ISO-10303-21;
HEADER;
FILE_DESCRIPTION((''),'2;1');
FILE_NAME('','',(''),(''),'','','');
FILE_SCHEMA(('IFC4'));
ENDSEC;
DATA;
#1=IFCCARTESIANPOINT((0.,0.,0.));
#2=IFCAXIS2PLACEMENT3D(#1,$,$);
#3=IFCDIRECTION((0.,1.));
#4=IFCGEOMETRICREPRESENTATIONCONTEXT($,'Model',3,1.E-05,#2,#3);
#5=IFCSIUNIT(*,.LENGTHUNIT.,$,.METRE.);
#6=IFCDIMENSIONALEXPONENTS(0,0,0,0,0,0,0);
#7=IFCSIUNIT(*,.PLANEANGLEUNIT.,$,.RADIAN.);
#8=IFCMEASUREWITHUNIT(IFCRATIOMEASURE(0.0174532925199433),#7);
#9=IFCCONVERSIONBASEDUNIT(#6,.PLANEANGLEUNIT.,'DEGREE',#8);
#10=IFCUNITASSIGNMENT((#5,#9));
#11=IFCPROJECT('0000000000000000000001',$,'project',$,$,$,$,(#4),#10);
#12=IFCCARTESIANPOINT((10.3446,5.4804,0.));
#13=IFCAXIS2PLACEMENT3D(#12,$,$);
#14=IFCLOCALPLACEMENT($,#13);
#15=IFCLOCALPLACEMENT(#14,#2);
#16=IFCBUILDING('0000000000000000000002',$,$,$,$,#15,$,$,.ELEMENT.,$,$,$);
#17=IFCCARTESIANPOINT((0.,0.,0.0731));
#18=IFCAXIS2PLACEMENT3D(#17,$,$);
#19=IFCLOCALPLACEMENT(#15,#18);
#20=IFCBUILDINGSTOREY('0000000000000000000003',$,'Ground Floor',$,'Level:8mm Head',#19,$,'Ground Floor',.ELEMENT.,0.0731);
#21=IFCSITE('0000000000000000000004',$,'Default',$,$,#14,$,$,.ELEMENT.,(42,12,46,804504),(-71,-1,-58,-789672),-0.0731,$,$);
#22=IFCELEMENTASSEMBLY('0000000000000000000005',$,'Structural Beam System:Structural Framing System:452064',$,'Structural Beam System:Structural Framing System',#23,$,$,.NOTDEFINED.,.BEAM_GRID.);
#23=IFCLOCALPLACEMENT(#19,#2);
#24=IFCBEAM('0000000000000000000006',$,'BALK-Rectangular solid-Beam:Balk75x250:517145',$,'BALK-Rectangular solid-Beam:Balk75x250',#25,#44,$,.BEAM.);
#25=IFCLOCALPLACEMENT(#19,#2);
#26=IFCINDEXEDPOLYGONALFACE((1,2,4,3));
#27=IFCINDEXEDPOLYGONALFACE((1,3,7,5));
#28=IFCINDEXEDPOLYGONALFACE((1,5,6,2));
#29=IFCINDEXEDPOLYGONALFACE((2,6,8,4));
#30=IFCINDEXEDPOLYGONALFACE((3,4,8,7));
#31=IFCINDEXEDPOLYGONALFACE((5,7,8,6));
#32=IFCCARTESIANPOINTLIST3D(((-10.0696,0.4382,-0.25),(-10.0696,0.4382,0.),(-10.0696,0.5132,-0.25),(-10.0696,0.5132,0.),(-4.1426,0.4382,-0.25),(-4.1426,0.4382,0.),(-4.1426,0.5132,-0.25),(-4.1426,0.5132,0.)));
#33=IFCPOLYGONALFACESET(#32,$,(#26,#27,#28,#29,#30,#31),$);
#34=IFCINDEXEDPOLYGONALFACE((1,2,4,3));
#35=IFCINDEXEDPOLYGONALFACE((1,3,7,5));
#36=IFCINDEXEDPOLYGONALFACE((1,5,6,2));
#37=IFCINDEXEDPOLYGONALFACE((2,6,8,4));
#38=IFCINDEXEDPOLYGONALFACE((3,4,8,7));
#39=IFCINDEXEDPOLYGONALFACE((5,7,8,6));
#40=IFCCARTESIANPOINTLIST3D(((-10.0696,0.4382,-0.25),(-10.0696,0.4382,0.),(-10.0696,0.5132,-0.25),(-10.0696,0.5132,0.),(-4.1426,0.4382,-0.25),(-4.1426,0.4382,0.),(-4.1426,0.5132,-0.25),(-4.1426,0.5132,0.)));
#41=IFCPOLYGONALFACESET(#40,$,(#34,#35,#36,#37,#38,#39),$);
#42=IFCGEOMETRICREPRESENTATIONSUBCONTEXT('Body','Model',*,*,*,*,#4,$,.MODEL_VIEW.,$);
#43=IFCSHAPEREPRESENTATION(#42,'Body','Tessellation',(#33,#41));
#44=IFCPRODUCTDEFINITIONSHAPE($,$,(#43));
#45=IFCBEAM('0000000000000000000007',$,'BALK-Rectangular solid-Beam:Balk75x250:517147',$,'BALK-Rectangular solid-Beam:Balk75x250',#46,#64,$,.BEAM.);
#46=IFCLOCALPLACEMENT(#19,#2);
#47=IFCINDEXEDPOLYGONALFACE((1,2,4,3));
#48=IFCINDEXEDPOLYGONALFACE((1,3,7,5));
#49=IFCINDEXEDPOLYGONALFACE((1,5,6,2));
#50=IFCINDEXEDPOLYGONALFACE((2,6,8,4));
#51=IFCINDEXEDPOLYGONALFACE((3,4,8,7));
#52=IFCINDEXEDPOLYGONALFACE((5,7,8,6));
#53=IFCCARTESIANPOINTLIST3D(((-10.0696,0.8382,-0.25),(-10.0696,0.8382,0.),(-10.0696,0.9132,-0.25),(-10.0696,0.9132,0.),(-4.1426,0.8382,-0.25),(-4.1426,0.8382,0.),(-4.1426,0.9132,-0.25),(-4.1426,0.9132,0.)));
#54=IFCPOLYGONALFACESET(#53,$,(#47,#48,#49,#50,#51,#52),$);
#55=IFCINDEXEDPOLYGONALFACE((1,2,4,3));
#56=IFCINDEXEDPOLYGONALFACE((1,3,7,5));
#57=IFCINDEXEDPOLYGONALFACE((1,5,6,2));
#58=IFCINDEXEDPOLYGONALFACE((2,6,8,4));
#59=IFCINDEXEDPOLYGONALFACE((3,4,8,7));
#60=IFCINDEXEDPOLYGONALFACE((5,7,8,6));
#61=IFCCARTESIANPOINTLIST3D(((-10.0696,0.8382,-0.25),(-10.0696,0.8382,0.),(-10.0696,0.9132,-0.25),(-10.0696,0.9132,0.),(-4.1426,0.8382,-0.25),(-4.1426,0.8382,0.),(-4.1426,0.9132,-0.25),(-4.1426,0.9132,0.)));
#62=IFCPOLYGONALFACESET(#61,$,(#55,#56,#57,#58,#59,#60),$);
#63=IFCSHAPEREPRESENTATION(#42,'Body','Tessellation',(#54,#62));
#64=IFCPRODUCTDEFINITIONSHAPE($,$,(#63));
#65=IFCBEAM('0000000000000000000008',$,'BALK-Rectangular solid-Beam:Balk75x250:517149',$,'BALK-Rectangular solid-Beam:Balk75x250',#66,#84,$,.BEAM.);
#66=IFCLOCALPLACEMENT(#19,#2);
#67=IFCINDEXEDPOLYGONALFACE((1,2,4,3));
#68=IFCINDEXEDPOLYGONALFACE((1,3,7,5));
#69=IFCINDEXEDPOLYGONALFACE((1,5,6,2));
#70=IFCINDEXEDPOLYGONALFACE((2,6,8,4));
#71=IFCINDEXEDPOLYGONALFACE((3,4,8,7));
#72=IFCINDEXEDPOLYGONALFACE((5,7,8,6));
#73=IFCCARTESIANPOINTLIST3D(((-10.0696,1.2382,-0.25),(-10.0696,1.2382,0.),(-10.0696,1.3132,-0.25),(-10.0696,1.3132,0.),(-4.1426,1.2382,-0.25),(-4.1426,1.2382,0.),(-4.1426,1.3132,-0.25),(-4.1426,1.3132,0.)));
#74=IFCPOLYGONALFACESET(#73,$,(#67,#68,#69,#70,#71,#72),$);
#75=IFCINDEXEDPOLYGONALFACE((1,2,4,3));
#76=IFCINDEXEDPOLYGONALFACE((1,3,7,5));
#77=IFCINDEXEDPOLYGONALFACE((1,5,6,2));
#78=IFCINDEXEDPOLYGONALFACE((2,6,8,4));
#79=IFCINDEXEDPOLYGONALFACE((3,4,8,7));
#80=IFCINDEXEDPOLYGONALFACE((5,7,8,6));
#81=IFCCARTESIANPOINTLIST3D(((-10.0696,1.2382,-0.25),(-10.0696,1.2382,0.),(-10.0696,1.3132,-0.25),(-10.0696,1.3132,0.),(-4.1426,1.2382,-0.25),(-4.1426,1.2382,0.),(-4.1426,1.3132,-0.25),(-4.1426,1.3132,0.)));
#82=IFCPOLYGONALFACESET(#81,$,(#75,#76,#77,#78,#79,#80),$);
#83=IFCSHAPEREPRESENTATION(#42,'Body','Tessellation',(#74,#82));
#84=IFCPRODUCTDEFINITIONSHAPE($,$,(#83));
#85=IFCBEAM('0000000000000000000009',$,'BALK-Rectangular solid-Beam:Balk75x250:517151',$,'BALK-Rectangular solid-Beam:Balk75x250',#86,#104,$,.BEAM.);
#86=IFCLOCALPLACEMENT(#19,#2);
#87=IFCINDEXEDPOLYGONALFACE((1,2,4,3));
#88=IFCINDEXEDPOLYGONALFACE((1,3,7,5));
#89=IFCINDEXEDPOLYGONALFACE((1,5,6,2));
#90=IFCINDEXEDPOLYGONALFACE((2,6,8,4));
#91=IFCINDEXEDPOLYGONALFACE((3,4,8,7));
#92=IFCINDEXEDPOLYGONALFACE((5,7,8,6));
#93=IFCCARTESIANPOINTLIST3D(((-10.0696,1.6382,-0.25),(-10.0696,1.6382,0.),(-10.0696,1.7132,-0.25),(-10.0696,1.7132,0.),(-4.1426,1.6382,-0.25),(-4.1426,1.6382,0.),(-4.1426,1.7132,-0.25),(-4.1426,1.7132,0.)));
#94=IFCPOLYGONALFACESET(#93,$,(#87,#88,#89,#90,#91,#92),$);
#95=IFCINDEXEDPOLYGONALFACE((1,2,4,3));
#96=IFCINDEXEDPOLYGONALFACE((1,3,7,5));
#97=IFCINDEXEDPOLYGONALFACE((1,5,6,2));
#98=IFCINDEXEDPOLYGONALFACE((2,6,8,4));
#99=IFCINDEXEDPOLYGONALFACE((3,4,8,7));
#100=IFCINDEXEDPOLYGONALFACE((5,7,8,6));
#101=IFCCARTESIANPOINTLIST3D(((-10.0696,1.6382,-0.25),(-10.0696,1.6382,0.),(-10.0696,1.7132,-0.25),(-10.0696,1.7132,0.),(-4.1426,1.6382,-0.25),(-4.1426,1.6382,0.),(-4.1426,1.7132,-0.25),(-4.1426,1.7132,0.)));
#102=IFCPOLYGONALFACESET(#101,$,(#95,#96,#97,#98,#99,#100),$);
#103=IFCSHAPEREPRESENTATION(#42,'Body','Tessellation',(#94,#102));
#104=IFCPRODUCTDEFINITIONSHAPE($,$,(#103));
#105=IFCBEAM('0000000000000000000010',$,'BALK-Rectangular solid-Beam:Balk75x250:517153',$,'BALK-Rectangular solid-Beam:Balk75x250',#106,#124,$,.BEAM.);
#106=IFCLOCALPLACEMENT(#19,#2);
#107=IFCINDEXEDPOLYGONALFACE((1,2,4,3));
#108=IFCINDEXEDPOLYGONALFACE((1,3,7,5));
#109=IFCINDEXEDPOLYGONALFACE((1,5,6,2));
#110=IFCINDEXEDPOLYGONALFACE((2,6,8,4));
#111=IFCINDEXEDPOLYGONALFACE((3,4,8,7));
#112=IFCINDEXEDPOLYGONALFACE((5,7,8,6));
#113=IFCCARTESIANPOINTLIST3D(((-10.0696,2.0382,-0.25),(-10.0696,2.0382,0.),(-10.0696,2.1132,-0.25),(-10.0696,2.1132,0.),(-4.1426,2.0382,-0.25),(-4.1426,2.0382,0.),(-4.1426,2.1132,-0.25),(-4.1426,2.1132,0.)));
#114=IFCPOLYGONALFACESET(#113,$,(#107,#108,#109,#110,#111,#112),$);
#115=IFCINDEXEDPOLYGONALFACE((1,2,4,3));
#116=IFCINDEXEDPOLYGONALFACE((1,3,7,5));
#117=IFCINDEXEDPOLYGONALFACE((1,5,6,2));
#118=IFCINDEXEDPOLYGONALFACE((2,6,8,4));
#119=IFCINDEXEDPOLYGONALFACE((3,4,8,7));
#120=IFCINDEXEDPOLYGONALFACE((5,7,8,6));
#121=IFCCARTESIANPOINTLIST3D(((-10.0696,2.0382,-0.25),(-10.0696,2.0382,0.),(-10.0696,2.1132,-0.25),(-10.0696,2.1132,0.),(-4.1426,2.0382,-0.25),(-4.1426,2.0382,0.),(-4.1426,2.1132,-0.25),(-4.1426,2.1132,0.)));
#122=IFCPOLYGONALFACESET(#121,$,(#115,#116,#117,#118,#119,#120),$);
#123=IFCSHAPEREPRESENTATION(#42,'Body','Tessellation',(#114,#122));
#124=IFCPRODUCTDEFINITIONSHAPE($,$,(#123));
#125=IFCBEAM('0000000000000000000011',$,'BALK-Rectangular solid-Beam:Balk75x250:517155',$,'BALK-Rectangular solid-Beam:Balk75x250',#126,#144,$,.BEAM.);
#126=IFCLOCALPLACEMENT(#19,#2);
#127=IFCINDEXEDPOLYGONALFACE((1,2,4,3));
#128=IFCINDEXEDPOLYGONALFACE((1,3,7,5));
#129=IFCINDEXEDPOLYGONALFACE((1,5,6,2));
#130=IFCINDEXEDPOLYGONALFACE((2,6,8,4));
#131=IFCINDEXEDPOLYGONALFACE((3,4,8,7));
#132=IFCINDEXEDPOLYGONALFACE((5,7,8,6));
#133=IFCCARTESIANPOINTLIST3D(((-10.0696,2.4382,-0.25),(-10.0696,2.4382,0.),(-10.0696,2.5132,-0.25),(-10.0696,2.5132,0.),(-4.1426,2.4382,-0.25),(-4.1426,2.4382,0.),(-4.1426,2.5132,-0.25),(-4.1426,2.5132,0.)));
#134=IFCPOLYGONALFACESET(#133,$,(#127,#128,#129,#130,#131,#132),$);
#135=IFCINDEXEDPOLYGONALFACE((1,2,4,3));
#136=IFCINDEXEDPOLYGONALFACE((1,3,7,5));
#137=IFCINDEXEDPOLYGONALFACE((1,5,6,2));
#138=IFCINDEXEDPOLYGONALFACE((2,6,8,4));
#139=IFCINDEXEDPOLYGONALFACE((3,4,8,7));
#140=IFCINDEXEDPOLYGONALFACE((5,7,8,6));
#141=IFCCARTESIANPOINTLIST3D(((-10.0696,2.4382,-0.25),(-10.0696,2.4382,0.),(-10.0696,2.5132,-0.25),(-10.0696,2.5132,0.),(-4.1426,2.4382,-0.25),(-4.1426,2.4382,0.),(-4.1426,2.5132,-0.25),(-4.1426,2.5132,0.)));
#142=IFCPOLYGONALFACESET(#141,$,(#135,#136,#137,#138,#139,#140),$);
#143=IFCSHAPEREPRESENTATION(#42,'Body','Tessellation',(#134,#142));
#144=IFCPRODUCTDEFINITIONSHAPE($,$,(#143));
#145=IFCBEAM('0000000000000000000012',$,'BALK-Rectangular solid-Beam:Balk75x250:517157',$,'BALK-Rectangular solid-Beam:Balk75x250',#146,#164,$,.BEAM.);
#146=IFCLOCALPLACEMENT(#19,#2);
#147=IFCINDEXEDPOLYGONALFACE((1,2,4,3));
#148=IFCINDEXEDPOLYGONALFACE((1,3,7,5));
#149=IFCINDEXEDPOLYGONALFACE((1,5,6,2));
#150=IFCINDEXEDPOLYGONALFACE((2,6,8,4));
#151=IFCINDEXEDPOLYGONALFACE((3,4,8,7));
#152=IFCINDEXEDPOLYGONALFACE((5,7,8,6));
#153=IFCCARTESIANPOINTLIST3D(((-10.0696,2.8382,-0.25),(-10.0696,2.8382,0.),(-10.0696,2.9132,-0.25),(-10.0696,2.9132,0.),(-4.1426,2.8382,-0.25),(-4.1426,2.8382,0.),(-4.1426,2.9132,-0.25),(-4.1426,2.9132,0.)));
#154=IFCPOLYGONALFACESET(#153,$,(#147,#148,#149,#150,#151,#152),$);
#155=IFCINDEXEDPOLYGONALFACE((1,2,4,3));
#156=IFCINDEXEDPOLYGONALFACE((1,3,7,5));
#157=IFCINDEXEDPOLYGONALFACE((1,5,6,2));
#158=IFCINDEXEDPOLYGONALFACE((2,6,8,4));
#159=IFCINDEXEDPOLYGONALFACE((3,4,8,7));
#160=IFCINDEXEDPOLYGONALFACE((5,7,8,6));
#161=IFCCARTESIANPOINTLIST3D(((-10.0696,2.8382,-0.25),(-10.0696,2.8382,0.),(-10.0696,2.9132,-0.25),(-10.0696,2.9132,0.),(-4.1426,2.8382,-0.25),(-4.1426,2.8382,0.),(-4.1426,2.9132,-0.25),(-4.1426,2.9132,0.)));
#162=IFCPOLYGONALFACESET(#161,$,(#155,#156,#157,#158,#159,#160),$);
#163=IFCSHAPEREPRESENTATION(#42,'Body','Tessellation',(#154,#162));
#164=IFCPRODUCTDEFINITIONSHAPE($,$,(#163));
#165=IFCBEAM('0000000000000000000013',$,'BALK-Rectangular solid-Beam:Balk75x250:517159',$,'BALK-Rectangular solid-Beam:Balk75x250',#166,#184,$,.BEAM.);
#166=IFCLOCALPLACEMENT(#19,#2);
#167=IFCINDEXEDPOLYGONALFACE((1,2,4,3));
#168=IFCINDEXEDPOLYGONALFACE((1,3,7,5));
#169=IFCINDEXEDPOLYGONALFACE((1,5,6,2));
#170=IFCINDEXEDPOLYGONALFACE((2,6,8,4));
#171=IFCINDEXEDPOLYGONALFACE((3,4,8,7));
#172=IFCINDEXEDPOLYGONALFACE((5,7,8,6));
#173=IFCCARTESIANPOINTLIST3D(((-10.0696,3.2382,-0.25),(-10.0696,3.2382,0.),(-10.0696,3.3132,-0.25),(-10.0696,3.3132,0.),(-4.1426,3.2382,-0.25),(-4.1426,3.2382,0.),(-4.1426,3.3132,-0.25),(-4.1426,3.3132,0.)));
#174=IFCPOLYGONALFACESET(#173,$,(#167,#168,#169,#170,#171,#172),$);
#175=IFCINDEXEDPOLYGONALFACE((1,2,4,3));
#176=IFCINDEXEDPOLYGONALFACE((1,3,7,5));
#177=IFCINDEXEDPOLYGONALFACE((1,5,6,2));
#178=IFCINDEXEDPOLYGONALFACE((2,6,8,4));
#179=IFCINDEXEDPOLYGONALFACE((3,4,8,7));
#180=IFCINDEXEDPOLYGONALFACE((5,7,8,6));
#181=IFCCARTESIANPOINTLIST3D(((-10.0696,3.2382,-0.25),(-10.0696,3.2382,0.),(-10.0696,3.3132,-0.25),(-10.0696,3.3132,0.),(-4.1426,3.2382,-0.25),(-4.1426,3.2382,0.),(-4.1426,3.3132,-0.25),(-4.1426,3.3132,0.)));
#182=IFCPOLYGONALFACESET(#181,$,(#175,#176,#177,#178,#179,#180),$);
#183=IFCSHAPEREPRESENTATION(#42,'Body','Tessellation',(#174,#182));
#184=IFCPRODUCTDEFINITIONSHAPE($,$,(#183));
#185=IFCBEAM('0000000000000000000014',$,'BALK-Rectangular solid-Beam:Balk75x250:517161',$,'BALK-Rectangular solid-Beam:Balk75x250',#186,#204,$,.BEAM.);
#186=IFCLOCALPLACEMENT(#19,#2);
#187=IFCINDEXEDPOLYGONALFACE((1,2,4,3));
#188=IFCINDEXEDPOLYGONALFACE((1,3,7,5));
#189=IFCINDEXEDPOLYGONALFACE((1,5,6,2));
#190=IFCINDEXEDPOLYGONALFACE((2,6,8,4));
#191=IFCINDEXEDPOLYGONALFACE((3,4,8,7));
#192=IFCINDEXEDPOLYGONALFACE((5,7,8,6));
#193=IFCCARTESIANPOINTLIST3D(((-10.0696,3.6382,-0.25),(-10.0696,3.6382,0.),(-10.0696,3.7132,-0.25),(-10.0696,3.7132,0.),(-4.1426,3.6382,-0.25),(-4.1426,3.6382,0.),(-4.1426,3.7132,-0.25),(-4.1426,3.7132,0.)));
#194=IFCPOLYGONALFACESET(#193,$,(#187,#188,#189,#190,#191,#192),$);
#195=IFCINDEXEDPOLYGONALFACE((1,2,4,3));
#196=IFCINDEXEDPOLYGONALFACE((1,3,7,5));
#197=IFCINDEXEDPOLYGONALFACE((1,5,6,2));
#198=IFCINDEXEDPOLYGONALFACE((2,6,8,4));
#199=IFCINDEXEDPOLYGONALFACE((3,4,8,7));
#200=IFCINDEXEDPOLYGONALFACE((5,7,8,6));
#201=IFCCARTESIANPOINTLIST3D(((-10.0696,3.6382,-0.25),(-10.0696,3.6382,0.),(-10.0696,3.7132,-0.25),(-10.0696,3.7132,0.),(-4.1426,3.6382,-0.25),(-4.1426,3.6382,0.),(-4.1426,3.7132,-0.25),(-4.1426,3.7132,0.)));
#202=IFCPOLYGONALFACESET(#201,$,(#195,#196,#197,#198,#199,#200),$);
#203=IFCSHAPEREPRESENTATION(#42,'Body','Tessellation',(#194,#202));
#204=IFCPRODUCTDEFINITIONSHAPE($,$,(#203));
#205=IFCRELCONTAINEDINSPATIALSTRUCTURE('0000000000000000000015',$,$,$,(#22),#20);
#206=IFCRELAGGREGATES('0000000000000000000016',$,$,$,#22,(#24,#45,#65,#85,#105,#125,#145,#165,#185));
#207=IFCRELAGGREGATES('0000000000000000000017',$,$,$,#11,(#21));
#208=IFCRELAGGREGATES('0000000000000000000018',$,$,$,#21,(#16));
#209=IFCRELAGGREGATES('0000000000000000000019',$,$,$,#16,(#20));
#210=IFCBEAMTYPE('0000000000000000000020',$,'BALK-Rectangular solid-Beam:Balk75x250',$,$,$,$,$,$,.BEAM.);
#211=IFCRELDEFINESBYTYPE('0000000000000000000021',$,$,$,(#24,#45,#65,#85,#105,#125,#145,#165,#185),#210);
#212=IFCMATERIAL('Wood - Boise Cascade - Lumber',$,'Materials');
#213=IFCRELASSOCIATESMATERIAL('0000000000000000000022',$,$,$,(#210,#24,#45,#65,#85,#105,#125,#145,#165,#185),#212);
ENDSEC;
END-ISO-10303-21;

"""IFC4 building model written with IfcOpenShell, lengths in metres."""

from ifc_helpers import new_model, entity, si_unit, converted_unit, direction, frame, frame_2d, origin, origin_2d_with_axis, place, context, subcontext, project, spatial, rectangle, extrude, source, transform, mapped, material, material_profile, profile_set, profile_usage, type_object, type_shapes, element, aggregate, save


model = new_model("IFC4")

# Units and contexts
model_context = context("Model", 3, precision=1e-05, world=origin(), true_north=direction((0.0, 1.0)))
body_context = subcontext(model_context, "Body", "Model", "MODEL_VIEW")
ifc_project = project(units=[si_unit("LENGTHUNIT", "METRE"), converted_unit("PLANEANGLEUNIT", "DEGREE", entity("IfcRatioMeasure", 0.0174532925199433), si_unit("PLANEANGLEUNIT", "RADIAN"), dimensions=[0, 0, 0, 0, 0, 0, 0])], contexts=[model_context])

# Site, building, storey
site_placement = place(None, frame((10.3446, 5.4804, 0.0)))
site = spatial("IfcSite", under=ifc_project, at=site_placement, Name="Default", CompositionType="ELEMENT", RefLatitude=(42, 12, 46, 804504), RefLongitude=(-71, -1, -58, -789672), RefElevation=-0.0731)
building_placement = place(site_placement, origin())
building = spatial("IfcBuilding", under=site, at=building_placement, CompositionType="ELEMENT")
storey_placement = place(building_placement, frame((0.0, 0.0, 0.0731)))
storey = spatial("IfcBuildingStorey", under=building, at=storey_placement, Name="Ground Floor", ObjectType="Level:8mm Head", LongName="Ground Floor", CompositionType="ELEMENT", Elevation=0.0731)

# Element assembly, beams
assembly_placement = place(storey_placement, origin())
assembly = element("IfcElementAssembly", 1, at=assembly_placement, inside=storey, Name="Structural Beam System:Structural Framing System:452064", ObjectType="Structural Beam System:Structural Framing System", AssemblyPlace="NOTDEFINED", PredefinedType="BEAM_GRID")
ifc_material_1 = material(Name="Wood - Boise Cascade - Lumber", Category="Materials")
ifc_material_profile = material_profile(ifc_material_1, rectangle(XDim=0.25, YDim=0.075, at=frame_2d((0.0, 0.0), x_axis=(1.0, 0.0))), Name="Balk75x250")
ifc_profile_set = profile_set([ifc_material_profile], Name="Balk75x250")
beam_type = type_object("IfcBeamType", Name="BALK-Rectangular solid-Beam:Balk75x250", PredefinedType="BEAM", material=ifc_profile_set)
shared_shape = source(origin(), body_context, "Body", "SweptSolid", [
    extrude(rectangle(XDim=0.25, YDim=0.075, at=origin_2d_with_axis()), frame((-2.9573, 0.0, 0.0), z_axis=(1.0, 0.0, 0.0), x_axis=(0.0, 0.0, -1.0)), (0.0, 0.0, 1.0), 5.927),
    extrude(rectangle(XDim=0.25, YDim=0.075, at=origin_2d_with_axis()), frame((-2.9573, 0.0, 0.0), z_axis=(1.0, 0.0, 0.0), x_axis=(0.0, 0.0, -1.0)), (0.0, 0.0, 1.0), 5.927),
])
type_shapes(beam_type, [shared_shape])
ifc_profile_usage_1 = profile_usage(ifc_profile_set, cardinal=8)
beam_1_placement = place(assembly_placement, frame((-7.0999, 0.4757, -0.125), z_axis=(0.0, 0.0, 1.0), x_axis=(-1.0, 0.0, 0.0)))
beam_1 = element("IfcBeam", 2, at=beam_1_placement, type_object=beam_type, material=ifc_profile_usage_1, Name="BALK-Rectangular solid-Beam:Balk75x250:517145", ObjectType="BALK-Rectangular solid-Beam:Balk75x250", PredefinedType="BEAM", context=body_context, shape_type="MappedRepresentation", body=[
    mapped(shared_shape, transform((0.0, 0.0, 0.0), scale=1.0)),
])
ifc_profile_usage_2 = profile_usage(ifc_profile_set, cardinal=8)
beam_2_placement = place(assembly_placement, frame((-7.0999, 0.8757, -0.125), z_axis=(0.0, 0.0, 1.0), x_axis=(-1.0, 0.0, 0.0)))
beam_2 = element("IfcBeam", 3, at=beam_2_placement, type_object=beam_type, material=ifc_profile_usage_2, Name="BALK-Rectangular solid-Beam:Balk75x250:517147", ObjectType="BALK-Rectangular solid-Beam:Balk75x250", PredefinedType="BEAM", context=body_context, shape_type="MappedRepresentation", body=[
    mapped(shared_shape, transform((0.0, 0.0, 0.0), scale=1.0)),
])
ifc_profile_usage_3 = profile_usage(ifc_profile_set, cardinal=8)
beam_3_placement = place(assembly_placement, frame((-7.0999, 1.2757, -0.125), z_axis=(0.0, 0.0, 1.0), x_axis=(-1.0, 0.0, 0.0)))
beam_3 = element("IfcBeam", 4, at=beam_3_placement, type_object=beam_type, material=ifc_profile_usage_3, Name="BALK-Rectangular solid-Beam:Balk75x250:517149", ObjectType="BALK-Rectangular solid-Beam:Balk75x250", PredefinedType="BEAM", context=body_context, shape_type="MappedRepresentation", body=[
    mapped(shared_shape, transform((0.0, 0.0, 0.0), scale=1.0)),
])
ifc_profile_usage_4 = profile_usage(ifc_profile_set, cardinal=8)
beam_4_placement = place(assembly_placement, frame((-7.0999, 1.6757, -0.125), z_axis=(0.0, 0.0, 1.0), x_axis=(-1.0, 0.0, 0.0)))
beam_4 = element("IfcBeam", 5, at=beam_4_placement, type_object=beam_type, material=ifc_profile_usage_4, Name="BALK-Rectangular solid-Beam:Balk75x250:517151", ObjectType="BALK-Rectangular solid-Beam:Balk75x250", PredefinedType="BEAM", context=body_context, shape_type="MappedRepresentation", body=[
    mapped(shared_shape, transform((0.0, 0.0, 0.0), scale=1.0)),
])
ifc_profile_usage_5 = profile_usage(ifc_profile_set, cardinal=8)
beam_5_placement = place(assembly_placement, frame((-7.0999, 2.0757, -0.125), z_axis=(0.0, 0.0, 1.0), x_axis=(-1.0, 0.0, 0.0)))
beam_5 = element("IfcBeam", 6, at=beam_5_placement, type_object=beam_type, material=ifc_profile_usage_5, Name="BALK-Rectangular solid-Beam:Balk75x250:517153", ObjectType="BALK-Rectangular solid-Beam:Balk75x250", PredefinedType="BEAM", context=body_context, shape_type="MappedRepresentation", body=[
    mapped(shared_shape, transform((0.0, 0.0, 0.0), scale=1.0)),
])
ifc_profile_usage_6 = profile_usage(ifc_profile_set, cardinal=8)
beam_6_placement = place(assembly_placement, frame((-7.0999, 2.4757, -0.125), z_axis=(0.0, 0.0, 1.0), x_axis=(-1.0, 0.0, 0.0)))
beam_6 = element("IfcBeam", 7, at=beam_6_placement, type_object=beam_type, material=ifc_profile_usage_6, Name="BALK-Rectangular solid-Beam:Balk75x250:517155", ObjectType="BALK-Rectangular solid-Beam:Balk75x250", PredefinedType="BEAM", context=body_context, shape_type="MappedRepresentation", body=[
    mapped(shared_shape, transform((0.0, 0.0, 0.0), scale=1.0)),
])
ifc_profile_usage_7 = profile_usage(ifc_profile_set, cardinal=8)
beam_7_placement = place(assembly_placement, frame((-7.0999, 2.8757, -0.125), z_axis=(0.0, 0.0, 1.0), x_axis=(-1.0, 0.0, 0.0)))
beam_7 = element("IfcBeam", 8, at=beam_7_placement, type_object=beam_type, material=ifc_profile_usage_7, Name="BALK-Rectangular solid-Beam:Balk75x250:517157", ObjectType="BALK-Rectangular solid-Beam:Balk75x250", PredefinedType="BEAM", context=body_context, shape_type="MappedRepresentation", body=[
    mapped(shared_shape, transform((0.0, 0.0, 0.0), scale=1.0)),
])
ifc_profile_usage_8 = profile_usage(ifc_profile_set, cardinal=8)
beam_8_placement = place(assembly_placement, frame((-7.0999, 3.2757, -0.125), z_axis=(0.0, 0.0, 1.0), x_axis=(-1.0, 0.0, 0.0)))
beam_8 = element("IfcBeam", 9, at=beam_8_placement, type_object=beam_type, material=ifc_profile_usage_8, Name="BALK-Rectangular solid-Beam:Balk75x250:517159", ObjectType="BALK-Rectangular solid-Beam:Balk75x250", PredefinedType="BEAM", context=body_context, shape_type="MappedRepresentation", body=[
    mapped(shared_shape, transform((0.0, 0.0, 0.0), scale=1.0)),
])
ifc_profile_usage_9 = profile_usage(ifc_profile_set, cardinal=8)
beam_9_placement = place(assembly_placement, frame((-7.0999, 3.6757, -0.125), z_axis=(0.0, 0.0, 1.0), x_axis=(-1.0, 0.0, 0.0)))
beam_9 = element("IfcBeam", 10, at=beam_9_placement, type_object=beam_type, material=ifc_profile_usage_9, Name="BALK-Rectangular solid-Beam:Balk75x250:517161", ObjectType="BALK-Rectangular solid-Beam:Balk75x250", PredefinedType="BEAM", context=body_context, shape_type="MappedRepresentation", body=[
    mapped(shared_shape, transform((0.0, 0.0, 0.0), scale=1.0)),
])
aggregate(assembly, [beam_1, beam_2, beam_3, beam_4, beam_5, beam_6, beam_7, beam_8, beam_9])

save(model, "model.ifc")
